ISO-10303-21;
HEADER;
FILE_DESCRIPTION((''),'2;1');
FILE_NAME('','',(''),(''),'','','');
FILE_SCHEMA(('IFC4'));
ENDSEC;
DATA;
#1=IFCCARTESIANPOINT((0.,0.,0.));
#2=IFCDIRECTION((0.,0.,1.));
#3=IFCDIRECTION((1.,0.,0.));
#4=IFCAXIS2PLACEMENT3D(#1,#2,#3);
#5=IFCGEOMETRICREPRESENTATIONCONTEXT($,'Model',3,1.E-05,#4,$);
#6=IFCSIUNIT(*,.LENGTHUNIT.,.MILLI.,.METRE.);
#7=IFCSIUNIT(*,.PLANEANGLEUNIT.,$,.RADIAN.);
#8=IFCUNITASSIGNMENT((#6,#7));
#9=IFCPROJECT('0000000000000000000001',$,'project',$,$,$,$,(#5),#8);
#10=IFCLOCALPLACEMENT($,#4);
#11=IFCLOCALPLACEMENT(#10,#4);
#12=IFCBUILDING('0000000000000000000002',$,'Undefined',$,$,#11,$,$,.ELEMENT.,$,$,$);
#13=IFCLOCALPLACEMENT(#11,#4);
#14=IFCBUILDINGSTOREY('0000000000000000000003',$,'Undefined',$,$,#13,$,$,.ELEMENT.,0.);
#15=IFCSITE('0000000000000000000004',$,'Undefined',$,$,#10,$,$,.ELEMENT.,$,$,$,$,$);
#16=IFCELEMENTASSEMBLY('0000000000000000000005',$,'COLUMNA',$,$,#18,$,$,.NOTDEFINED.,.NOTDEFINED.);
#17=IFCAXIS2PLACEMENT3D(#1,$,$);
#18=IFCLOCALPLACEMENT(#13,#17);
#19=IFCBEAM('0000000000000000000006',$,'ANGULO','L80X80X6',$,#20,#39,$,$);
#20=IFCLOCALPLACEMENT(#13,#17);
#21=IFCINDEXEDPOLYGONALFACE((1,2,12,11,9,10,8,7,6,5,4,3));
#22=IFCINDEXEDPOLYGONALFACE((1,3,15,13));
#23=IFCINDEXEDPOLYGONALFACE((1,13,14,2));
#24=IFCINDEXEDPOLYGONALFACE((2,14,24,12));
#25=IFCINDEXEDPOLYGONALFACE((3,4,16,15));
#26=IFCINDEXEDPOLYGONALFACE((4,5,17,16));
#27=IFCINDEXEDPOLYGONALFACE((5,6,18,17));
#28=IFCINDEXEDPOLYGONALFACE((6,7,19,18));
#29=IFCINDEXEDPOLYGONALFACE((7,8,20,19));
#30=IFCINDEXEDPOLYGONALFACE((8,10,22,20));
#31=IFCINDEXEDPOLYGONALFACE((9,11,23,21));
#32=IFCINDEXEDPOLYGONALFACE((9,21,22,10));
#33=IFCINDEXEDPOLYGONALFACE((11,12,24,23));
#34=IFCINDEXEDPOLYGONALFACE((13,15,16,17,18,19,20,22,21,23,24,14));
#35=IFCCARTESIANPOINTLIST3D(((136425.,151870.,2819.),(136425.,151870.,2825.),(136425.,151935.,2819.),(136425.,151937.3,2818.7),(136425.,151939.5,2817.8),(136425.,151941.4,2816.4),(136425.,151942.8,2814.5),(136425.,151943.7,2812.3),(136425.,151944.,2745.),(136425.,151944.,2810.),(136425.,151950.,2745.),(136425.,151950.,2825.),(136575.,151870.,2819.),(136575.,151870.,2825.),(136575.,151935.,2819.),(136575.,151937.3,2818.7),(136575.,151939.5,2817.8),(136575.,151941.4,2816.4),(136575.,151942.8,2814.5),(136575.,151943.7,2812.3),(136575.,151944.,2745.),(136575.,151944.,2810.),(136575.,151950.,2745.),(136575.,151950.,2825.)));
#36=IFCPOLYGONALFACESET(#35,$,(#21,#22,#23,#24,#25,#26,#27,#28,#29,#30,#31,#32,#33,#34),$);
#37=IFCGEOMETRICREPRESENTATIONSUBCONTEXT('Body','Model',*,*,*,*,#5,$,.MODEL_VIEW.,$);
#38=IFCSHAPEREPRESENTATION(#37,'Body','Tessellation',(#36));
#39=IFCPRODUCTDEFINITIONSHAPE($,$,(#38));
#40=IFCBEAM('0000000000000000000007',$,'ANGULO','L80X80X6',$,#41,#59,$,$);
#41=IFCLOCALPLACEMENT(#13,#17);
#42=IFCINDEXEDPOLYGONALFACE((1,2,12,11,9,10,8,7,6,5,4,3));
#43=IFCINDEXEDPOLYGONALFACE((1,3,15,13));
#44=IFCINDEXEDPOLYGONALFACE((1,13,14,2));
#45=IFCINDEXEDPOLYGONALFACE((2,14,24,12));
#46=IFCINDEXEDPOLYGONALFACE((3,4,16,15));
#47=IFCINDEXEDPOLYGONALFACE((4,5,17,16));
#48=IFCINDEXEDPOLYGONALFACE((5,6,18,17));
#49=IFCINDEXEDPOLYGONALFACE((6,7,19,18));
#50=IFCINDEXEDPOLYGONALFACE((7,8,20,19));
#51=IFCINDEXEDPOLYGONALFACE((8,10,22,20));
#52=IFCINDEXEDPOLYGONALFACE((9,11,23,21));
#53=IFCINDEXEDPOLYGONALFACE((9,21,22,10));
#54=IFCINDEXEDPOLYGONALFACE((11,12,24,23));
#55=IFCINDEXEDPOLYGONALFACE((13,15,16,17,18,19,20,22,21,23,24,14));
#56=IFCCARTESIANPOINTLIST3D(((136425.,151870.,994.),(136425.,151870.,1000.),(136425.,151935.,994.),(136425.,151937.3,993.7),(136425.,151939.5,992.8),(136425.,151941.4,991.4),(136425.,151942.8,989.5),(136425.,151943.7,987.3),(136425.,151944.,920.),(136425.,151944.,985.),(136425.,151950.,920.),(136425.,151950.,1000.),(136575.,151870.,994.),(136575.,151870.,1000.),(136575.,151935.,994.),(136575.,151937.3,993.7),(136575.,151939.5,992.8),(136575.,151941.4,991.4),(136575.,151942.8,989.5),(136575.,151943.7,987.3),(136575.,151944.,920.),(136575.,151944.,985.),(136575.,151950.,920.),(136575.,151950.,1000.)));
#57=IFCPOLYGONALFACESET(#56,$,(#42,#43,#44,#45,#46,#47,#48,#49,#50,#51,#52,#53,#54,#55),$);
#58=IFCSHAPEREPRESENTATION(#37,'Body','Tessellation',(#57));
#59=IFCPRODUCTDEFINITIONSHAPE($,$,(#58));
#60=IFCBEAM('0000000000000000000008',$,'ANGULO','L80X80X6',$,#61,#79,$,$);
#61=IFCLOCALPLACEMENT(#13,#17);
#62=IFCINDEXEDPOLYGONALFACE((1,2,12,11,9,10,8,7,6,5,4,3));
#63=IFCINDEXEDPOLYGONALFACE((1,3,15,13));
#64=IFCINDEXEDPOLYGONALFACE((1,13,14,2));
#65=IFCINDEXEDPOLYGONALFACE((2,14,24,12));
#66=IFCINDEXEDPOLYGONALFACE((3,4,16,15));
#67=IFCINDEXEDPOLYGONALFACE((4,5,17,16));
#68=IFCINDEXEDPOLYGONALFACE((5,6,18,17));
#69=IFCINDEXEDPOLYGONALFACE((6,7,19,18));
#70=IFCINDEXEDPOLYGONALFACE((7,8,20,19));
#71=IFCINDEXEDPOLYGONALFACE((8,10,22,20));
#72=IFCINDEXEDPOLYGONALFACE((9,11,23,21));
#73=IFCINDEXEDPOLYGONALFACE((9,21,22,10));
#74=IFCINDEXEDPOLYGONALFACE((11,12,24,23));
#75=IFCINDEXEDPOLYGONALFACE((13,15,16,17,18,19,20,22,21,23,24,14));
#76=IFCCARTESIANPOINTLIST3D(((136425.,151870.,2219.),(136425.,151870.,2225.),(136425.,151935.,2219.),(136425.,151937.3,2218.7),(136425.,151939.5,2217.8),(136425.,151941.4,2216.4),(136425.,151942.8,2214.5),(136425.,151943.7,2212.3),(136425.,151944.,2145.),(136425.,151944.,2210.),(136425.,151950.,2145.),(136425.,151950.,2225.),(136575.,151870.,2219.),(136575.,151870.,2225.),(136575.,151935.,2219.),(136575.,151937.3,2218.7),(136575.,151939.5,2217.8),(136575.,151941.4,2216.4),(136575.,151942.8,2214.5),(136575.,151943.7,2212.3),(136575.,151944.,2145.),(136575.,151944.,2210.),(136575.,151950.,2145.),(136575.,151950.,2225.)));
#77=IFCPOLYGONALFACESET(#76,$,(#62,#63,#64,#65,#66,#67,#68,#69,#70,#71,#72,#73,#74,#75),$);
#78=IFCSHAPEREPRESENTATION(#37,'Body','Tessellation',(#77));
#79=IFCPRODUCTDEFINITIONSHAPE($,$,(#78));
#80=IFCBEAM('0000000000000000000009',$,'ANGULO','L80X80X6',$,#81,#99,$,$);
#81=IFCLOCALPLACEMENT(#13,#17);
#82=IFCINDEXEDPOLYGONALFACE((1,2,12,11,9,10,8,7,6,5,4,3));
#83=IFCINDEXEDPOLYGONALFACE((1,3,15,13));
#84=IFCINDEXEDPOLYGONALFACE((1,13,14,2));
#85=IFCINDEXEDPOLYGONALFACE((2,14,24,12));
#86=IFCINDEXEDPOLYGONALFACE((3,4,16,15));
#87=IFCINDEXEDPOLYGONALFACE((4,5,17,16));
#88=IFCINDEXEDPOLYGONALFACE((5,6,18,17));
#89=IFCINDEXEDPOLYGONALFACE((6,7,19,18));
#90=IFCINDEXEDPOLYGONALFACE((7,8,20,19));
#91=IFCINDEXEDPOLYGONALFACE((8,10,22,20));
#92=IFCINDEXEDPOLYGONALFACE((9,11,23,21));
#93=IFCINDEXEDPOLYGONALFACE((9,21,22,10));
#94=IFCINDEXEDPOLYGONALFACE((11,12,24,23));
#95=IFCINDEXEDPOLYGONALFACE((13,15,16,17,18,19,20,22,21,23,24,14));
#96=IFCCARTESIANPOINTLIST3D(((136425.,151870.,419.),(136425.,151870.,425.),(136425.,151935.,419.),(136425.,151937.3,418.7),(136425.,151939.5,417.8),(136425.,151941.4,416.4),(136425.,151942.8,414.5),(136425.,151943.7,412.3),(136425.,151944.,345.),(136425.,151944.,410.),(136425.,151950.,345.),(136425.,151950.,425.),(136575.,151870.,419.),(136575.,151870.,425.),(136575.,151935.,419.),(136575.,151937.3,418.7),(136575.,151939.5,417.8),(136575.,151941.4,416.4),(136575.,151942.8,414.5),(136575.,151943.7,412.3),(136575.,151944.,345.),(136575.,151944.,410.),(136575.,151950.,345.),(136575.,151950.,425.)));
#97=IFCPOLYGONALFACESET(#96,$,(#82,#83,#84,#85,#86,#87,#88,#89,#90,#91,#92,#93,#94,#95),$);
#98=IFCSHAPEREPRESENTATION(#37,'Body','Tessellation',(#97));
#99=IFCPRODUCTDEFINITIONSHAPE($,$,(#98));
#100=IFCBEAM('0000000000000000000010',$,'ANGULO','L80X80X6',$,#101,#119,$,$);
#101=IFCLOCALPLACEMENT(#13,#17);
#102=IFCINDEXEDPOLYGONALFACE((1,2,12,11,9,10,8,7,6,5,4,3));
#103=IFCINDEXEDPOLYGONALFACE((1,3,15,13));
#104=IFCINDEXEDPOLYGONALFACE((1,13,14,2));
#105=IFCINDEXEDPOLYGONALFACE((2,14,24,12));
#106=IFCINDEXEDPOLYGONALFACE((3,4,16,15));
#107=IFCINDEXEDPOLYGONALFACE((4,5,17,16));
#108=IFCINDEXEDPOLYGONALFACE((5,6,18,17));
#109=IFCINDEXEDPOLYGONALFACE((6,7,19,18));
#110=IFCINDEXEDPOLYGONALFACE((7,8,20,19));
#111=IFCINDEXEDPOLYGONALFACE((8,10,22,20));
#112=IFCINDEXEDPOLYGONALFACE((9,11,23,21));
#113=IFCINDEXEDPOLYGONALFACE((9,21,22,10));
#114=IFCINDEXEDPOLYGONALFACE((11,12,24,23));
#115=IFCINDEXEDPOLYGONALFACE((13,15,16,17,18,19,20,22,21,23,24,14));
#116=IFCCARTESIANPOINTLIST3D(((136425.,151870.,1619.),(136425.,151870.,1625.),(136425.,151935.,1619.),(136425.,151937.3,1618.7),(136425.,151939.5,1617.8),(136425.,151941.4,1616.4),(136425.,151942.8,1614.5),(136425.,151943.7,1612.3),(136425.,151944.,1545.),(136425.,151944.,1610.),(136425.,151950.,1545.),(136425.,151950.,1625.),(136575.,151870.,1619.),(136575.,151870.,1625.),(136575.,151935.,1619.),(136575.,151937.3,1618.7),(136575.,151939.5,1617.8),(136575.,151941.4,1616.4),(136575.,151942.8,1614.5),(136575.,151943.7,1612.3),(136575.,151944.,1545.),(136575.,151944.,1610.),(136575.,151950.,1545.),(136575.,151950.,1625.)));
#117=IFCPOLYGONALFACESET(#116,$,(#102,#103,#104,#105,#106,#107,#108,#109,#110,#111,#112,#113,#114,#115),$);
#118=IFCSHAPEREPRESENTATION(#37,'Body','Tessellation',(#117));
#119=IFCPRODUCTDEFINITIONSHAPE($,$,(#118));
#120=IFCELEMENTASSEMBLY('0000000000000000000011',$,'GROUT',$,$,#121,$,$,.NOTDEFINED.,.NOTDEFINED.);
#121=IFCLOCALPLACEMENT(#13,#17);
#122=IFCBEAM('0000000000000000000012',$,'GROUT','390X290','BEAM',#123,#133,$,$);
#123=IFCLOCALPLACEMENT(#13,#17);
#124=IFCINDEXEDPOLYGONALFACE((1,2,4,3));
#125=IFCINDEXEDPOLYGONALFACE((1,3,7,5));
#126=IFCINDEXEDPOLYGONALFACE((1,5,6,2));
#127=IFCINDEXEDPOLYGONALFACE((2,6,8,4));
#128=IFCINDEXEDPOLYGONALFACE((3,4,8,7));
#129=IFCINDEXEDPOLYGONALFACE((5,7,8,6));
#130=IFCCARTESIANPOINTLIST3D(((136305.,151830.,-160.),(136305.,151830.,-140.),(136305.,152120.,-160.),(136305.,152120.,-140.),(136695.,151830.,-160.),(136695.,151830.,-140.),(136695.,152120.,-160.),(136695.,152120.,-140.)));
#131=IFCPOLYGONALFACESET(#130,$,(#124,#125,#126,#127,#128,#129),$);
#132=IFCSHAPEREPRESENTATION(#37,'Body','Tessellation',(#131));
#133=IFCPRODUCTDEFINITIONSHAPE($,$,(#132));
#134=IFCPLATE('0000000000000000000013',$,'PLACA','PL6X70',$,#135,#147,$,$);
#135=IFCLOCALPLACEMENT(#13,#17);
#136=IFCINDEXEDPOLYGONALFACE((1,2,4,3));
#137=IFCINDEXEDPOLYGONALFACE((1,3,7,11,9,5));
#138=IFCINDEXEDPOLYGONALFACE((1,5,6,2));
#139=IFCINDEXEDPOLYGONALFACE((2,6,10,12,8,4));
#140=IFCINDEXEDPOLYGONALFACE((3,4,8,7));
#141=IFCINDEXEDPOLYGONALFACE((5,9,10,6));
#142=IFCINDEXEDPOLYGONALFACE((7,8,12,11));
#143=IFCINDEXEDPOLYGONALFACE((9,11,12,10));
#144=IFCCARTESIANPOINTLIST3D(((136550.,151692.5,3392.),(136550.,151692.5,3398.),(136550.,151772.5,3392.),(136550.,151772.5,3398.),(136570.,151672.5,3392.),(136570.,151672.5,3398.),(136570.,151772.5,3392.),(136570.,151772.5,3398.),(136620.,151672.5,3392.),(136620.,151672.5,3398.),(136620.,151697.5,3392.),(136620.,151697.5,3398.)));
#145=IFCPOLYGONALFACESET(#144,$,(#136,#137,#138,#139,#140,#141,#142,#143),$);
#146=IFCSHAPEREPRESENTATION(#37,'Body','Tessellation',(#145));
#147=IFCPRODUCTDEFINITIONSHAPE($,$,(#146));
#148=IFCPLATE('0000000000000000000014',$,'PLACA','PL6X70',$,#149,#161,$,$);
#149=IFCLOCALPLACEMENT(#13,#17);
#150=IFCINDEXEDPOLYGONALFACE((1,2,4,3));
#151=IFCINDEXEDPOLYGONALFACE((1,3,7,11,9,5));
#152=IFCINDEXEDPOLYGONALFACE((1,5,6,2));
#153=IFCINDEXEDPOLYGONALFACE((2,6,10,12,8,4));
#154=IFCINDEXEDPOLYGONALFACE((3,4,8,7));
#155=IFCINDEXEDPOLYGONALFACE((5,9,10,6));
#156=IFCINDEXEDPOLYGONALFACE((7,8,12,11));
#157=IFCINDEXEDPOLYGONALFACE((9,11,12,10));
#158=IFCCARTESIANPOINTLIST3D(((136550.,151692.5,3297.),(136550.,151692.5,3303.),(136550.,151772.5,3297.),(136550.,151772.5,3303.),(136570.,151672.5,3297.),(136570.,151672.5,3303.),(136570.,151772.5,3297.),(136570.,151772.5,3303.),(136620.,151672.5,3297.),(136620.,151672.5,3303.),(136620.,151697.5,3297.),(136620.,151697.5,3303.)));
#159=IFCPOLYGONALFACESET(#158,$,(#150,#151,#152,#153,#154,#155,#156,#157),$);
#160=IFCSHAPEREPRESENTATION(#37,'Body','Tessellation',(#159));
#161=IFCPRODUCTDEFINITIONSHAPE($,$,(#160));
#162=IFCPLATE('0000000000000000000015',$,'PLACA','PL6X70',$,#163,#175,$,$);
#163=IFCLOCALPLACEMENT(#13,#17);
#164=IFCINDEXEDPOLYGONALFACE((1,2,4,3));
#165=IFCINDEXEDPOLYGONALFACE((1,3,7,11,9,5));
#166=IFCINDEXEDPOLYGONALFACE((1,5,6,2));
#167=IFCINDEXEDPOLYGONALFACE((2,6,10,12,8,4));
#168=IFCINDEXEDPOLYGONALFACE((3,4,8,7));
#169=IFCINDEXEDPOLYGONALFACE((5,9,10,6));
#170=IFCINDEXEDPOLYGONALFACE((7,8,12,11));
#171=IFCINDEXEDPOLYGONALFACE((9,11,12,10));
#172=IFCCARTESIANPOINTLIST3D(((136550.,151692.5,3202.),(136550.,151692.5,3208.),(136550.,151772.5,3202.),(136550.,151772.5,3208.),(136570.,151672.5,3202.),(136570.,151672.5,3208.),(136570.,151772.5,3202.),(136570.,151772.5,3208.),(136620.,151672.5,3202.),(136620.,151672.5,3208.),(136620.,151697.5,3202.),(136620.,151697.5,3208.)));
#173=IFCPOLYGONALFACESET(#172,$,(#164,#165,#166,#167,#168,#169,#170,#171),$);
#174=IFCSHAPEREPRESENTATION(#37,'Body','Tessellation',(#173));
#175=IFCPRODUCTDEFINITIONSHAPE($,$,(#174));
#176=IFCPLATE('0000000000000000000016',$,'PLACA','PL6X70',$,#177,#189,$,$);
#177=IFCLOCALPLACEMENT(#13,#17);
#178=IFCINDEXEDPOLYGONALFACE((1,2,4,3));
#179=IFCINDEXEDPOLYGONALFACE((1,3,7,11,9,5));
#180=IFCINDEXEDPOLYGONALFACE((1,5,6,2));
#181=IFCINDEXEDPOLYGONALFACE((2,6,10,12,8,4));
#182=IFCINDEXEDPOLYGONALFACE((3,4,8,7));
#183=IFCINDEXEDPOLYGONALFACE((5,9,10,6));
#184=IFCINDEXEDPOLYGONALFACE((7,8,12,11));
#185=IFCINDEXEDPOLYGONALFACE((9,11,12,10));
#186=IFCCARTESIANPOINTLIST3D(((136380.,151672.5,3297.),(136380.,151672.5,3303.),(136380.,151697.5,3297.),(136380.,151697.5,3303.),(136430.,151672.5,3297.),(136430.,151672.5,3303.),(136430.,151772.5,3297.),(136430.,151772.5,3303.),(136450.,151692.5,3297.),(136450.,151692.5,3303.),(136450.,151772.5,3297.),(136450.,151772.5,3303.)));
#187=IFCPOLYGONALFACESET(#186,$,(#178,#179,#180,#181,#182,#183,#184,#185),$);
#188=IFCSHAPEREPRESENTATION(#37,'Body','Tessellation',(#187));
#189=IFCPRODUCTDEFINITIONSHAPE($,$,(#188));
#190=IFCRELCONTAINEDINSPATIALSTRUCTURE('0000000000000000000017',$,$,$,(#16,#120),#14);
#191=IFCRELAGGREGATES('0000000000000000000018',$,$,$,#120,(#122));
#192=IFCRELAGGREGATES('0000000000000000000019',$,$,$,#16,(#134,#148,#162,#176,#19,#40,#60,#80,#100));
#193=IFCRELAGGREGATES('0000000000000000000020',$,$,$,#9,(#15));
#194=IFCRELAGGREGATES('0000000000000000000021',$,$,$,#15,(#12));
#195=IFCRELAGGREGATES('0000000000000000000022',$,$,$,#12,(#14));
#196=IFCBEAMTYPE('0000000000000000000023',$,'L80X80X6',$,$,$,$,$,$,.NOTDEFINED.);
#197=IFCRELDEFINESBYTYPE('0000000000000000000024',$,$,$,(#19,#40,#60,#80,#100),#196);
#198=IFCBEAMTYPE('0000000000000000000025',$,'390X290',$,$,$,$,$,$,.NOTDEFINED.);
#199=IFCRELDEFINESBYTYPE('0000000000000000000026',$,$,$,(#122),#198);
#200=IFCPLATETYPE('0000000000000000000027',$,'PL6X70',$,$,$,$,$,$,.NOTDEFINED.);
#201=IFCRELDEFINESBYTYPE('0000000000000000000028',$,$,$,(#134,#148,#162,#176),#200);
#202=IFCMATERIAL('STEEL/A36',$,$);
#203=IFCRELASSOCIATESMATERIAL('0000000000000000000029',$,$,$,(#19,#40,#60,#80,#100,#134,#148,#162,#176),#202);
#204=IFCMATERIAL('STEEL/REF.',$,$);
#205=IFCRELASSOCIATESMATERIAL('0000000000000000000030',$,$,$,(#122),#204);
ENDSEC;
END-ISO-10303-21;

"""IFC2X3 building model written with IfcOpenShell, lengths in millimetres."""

from ifc_helpers import new_model, si_unit, frame, origin_with_axes, origin_2d_with_axis, place, context, subcontext, project, spatial, polyline, rectangle, l_section, outline, extrude, material, type_object, element, aggregate, save


model = new_model("IFC2X3")

# Units and contexts
model_context = context("Model", 3, precision=1e-05, world=origin_with_axes())
body_context = subcontext(model_context, "Body", "Model", "MODEL_VIEW")
ifc_project = project(units=[si_unit("LENGTHUNIT", "METRE", prefix="MILLI"), si_unit("PLANEANGLEUNIT", "RADIAN")], contexts=[model_context])

# Site, building, storey
site_placement = place(None, origin_with_axes())
site = spatial("IfcSite", under=ifc_project, at=site_placement, Name="Undefined", CompositionType="ELEMENT")
building_placement = place(site_placement, origin_with_axes())
building = spatial("IfcBuilding", under=site, at=building_placement, Name="Undefined", CompositionType="ELEMENT")
storey_placement = place(building_placement, origin_with_axes())
storey = spatial("IfcBuildingStorey", under=building, at=storey_placement, Name="Undefined", CompositionType="ELEMENT", Elevation=0.0)

# Element assembly
assembly_1_placement = place(storey_placement, origin_with_axes())
assembly_1 = element("IfcElementAssembly", 1, at=assembly_1_placement, inside=storey, Name="COLUMNA", AssemblyPlace="NOTDEFINED", PredefinedType="NOTDEFINED")
ifc_material_1 = material(Name="STEEL/A36")

# Beams
beam_type_1 = type_object("IfcBeamType", Name="L80X80X6", PredefinedType="NOTDEFINED")
beam_1_placement = place(assembly_1_placement, frame((136425.0, 151910.0, 2785.0), z_axis=(0.0, -1.0, 0.0), x_axis=(1.0, 0.0, 0.0)))
beam_1 = element("IfcBeam", 2, at=beam_1_placement, type_object=beam_type_1, material=ifc_material_1, Name="ANGULO", Description="L80X80X6", context=body_context, shape_type="SweptSolid", body=[
    extrude(l_section(Depth=80.0, Width=80.0, Thickness=6.0, FilletRadius=9.0, at=origin_2d_with_axis()), frame((150.0, 0.0, 0.0), z_axis=(-1.0, 0.0, 0.0), x_axis=(0.0, -1.0, 0.0)), (0.0, 0.0, 1.0), 150.0),
])
beam_2_placement = place(assembly_1_placement, frame((136425.0, 151910.0, 960.0), z_axis=(0.0, -1.0, 0.0), x_axis=(1.0, 0.0, 0.0)))
beam_2 = element("IfcBeam", 3, at=beam_2_placement, type_object=beam_type_1, material=ifc_material_1, Name="ANGULO", Description="L80X80X6", context=body_context, shape_type="SweptSolid", body=[
    extrude(l_section(Depth=80.0, Width=80.0, Thickness=6.0, FilletRadius=9.0, at=origin_2d_with_axis()), frame((150.0, 0.0, 0.0), z_axis=(-1.0, 0.0, 0.0), x_axis=(0.0, -1.0, 0.0)), (0.0, 0.0, 1.0), 150.0),
])
beam_3_placement = place(assembly_1_placement, frame((136425.0, 151910.0, 2185.0), z_axis=(0.0, -1.0, 0.0), x_axis=(1.0, 0.0, 0.0)))
beam_3 = element("IfcBeam", 4, at=beam_3_placement, type_object=beam_type_1, material=ifc_material_1, Name="ANGULO", Description="L80X80X6", context=body_context, shape_type="SweptSolid", body=[
    extrude(l_section(Depth=80.0, Width=80.0, Thickness=6.0, FilletRadius=9.0, at=origin_2d_with_axis()), frame((150.0, 0.0, 0.0), z_axis=(-1.0, 0.0, 0.0), x_axis=(0.0, -1.0, 0.0)), (0.0, 0.0, 1.0), 150.0),
])
beam_4_placement = place(assembly_1_placement, frame((136425.0, 151910.0, 385.0), z_axis=(0.0, -1.0, 0.0), x_axis=(1.0, 0.0, 0.0)))
beam_4 = element("IfcBeam", 5, at=beam_4_placement, type_object=beam_type_1, material=ifc_material_1, Name="ANGULO", Description="L80X80X6", context=body_context, shape_type="SweptSolid", body=[
    extrude(l_section(Depth=80.0, Width=80.0, Thickness=6.0, FilletRadius=9.0, at=origin_2d_with_axis()), frame((150.0, 0.0, 0.0), z_axis=(-1.0, 0.0, 0.0), x_axis=(0.0, -1.0, 0.0)), (0.0, 0.0, 1.0), 150.0),
])
beam_5_placement = place(assembly_1_placement, frame((136425.0, 151910.0, 1585.0), z_axis=(0.0, -1.0, 0.0), x_axis=(1.0, 0.0, 0.0)))
beam_5 = element("IfcBeam", 6, at=beam_5_placement, type_object=beam_type_1, material=ifc_material_1, Name="ANGULO", Description="L80X80X6", context=body_context, shape_type="SweptSolid", body=[
    extrude(l_section(Depth=80.0, Width=80.0, Thickness=6.0, FilletRadius=9.0, at=origin_2d_with_axis()), frame((150.0, 0.0, 0.0), z_axis=(-1.0, 0.0, 0.0), x_axis=(0.0, -1.0, 0.0)), (0.0, 0.0, 1.0), 150.0),
])

# Element assembly, beam
assembly_2_placement = place(storey_placement, origin_with_axes())
assembly_2 = element("IfcElementAssembly", 7, at=assembly_2_placement, inside=storey, Name="GROUT", AssemblyPlace="NOTDEFINED", PredefinedType="NOTDEFINED")
ifc_material_2 = material(Name="STEEL/REF.")
beam_type_2 = type_object("IfcBeamType", Name="390X290", PredefinedType="NOTDEFINED")
beam_6_placement = place(assembly_2_placement, frame((136500.0, 151975.0, -140.0), z_axis=(1.0, 0.0, 0.0), x_axis=(0.0, 0.0, -1.0)))
beam_6 = element("IfcBeam", 8, at=beam_6_placement, type_object=beam_type_2, material=ifc_material_2, Name="GROUT", Description="390X290", ObjectType="BEAM", context=body_context, shape_type="SweptSolid", body=[
    extrude(rectangle(XDim=290.0, YDim=390.0, at=origin_2d_with_axis()), frame((20.0, 0.0, 0.0), z_axis=(-1.0, 0.0, 0.0), x_axis=(0.0, -1.0, 0.0)), (0.0, 0.0, 1.0), 20.0),
])
aggregate(assembly_2, [beam_6])

# Plates
plate_type_1 = type_object("IfcPlateType", Name="PL6X70", PredefinedType="NOTDEFINED")
plate_1_placement = place(assembly_1_placement, frame((136620.0, 151672.5, 3395.0), z_axis=(0.0, 0.0, 1.0), x_axis=(0.0, 1.0, 0.0)))
plate_1 = element("IfcPlate", 9, at=plate_1_placement, type_object=plate_type_1, material=ifc_material_1, Name="PLACA", Description="PL6X70", context=body_context, shape_type="SweptSolid", body=[
    extrude(outline(polyline([(0.0, 0.0), (25.0, 0.0), (100.0, 50.0), (100.0, 70.0), (20.0, 70.0), (0.0, 50.0), (0.0, 0.0)])), frame((0.0, 0.0, -3.0), z_axis=(0.0, 0.0, 1.0), x_axis=(1.0, 0.0, 0.0)), (0.0, 0.0, 1.0), 6.0),
])
plate_2_placement = place(assembly_1_placement, frame((136620.0, 151672.5, 3300.0), z_axis=(0.0, 0.0, 1.0), x_axis=(0.0, 1.0, 0.0)))
plate_2 = element("IfcPlate", 10, at=plate_2_placement, type_object=plate_type_1, material=ifc_material_1, Name="PLACA", Description="PL6X70", context=body_context, shape_type="SweptSolid", body=[
    extrude(outline(polyline([(0.0, 0.0), (25.0, 0.0), (100.0, 50.0), (100.0, 70.0), (20.0, 70.0), (0.0, 50.0), (0.0, 0.0)])), frame((0.0, 0.0, -3.0), z_axis=(0.0, 0.0, 1.0), x_axis=(1.0, 0.0, 0.0)), (0.0, 0.0, 1.0), 6.0),
])
plate_3_placement = place(assembly_1_placement, frame((136620.0, 151672.5, 3205.0), z_axis=(0.0, 0.0, 1.0), x_axis=(0.0, 1.0, 0.0)))
plate_3 = element("IfcPlate", 11, at=plate_3_placement, type_object=plate_type_1, material=ifc_material_1, Name="PLACA", Description="PL6X70", context=body_context, shape_type="SweptSolid", body=[
    extrude(outline(polyline([(0.0, 0.0), (25.0, 0.0), (100.0, 50.0), (100.0, 70.0), (20.0, 70.0), (0.0, 50.0), (0.0, 0.0)])), frame((0.0, 0.0, -3.0), z_axis=(0.0, 0.0, 1.0), x_axis=(1.0, 0.0, 0.0)), (0.0, 0.0, 1.0), 6.0),
])
plate_4_placement = place(assembly_1_placement, frame((136380.0, 151672.5, 3300.0), z_axis=(0.0, 0.0, -1.0), x_axis=(0.0, 1.0, 0.0)))
plate_4 = element("IfcPlate", 12, at=plate_4_placement, type_object=plate_type_1, material=ifc_material_1, Name="PLACA", Description="PL6X70", context=body_context, shape_type="SweptSolid", body=[
    extrude(outline(polyline([(0.0, 0.0), (25.0, 0.0), (100.0, 50.0), (100.0, 70.0), (20.0, 70.0), (0.0, 50.0), (0.0, 0.0)])), frame((0.0, 0.0, -3.0), z_axis=(0.0, 0.0, 1.0), x_axis=(1.0, 0.0, 0.0)), (0.0, 0.0, 1.0), 6.0),
])

aggregate(assembly_1, [plate_1, plate_2, plate_3, plate_4, beam_1, beam_2, beam_3, beam_4, beam_5])

save(model, "model.ifc")
